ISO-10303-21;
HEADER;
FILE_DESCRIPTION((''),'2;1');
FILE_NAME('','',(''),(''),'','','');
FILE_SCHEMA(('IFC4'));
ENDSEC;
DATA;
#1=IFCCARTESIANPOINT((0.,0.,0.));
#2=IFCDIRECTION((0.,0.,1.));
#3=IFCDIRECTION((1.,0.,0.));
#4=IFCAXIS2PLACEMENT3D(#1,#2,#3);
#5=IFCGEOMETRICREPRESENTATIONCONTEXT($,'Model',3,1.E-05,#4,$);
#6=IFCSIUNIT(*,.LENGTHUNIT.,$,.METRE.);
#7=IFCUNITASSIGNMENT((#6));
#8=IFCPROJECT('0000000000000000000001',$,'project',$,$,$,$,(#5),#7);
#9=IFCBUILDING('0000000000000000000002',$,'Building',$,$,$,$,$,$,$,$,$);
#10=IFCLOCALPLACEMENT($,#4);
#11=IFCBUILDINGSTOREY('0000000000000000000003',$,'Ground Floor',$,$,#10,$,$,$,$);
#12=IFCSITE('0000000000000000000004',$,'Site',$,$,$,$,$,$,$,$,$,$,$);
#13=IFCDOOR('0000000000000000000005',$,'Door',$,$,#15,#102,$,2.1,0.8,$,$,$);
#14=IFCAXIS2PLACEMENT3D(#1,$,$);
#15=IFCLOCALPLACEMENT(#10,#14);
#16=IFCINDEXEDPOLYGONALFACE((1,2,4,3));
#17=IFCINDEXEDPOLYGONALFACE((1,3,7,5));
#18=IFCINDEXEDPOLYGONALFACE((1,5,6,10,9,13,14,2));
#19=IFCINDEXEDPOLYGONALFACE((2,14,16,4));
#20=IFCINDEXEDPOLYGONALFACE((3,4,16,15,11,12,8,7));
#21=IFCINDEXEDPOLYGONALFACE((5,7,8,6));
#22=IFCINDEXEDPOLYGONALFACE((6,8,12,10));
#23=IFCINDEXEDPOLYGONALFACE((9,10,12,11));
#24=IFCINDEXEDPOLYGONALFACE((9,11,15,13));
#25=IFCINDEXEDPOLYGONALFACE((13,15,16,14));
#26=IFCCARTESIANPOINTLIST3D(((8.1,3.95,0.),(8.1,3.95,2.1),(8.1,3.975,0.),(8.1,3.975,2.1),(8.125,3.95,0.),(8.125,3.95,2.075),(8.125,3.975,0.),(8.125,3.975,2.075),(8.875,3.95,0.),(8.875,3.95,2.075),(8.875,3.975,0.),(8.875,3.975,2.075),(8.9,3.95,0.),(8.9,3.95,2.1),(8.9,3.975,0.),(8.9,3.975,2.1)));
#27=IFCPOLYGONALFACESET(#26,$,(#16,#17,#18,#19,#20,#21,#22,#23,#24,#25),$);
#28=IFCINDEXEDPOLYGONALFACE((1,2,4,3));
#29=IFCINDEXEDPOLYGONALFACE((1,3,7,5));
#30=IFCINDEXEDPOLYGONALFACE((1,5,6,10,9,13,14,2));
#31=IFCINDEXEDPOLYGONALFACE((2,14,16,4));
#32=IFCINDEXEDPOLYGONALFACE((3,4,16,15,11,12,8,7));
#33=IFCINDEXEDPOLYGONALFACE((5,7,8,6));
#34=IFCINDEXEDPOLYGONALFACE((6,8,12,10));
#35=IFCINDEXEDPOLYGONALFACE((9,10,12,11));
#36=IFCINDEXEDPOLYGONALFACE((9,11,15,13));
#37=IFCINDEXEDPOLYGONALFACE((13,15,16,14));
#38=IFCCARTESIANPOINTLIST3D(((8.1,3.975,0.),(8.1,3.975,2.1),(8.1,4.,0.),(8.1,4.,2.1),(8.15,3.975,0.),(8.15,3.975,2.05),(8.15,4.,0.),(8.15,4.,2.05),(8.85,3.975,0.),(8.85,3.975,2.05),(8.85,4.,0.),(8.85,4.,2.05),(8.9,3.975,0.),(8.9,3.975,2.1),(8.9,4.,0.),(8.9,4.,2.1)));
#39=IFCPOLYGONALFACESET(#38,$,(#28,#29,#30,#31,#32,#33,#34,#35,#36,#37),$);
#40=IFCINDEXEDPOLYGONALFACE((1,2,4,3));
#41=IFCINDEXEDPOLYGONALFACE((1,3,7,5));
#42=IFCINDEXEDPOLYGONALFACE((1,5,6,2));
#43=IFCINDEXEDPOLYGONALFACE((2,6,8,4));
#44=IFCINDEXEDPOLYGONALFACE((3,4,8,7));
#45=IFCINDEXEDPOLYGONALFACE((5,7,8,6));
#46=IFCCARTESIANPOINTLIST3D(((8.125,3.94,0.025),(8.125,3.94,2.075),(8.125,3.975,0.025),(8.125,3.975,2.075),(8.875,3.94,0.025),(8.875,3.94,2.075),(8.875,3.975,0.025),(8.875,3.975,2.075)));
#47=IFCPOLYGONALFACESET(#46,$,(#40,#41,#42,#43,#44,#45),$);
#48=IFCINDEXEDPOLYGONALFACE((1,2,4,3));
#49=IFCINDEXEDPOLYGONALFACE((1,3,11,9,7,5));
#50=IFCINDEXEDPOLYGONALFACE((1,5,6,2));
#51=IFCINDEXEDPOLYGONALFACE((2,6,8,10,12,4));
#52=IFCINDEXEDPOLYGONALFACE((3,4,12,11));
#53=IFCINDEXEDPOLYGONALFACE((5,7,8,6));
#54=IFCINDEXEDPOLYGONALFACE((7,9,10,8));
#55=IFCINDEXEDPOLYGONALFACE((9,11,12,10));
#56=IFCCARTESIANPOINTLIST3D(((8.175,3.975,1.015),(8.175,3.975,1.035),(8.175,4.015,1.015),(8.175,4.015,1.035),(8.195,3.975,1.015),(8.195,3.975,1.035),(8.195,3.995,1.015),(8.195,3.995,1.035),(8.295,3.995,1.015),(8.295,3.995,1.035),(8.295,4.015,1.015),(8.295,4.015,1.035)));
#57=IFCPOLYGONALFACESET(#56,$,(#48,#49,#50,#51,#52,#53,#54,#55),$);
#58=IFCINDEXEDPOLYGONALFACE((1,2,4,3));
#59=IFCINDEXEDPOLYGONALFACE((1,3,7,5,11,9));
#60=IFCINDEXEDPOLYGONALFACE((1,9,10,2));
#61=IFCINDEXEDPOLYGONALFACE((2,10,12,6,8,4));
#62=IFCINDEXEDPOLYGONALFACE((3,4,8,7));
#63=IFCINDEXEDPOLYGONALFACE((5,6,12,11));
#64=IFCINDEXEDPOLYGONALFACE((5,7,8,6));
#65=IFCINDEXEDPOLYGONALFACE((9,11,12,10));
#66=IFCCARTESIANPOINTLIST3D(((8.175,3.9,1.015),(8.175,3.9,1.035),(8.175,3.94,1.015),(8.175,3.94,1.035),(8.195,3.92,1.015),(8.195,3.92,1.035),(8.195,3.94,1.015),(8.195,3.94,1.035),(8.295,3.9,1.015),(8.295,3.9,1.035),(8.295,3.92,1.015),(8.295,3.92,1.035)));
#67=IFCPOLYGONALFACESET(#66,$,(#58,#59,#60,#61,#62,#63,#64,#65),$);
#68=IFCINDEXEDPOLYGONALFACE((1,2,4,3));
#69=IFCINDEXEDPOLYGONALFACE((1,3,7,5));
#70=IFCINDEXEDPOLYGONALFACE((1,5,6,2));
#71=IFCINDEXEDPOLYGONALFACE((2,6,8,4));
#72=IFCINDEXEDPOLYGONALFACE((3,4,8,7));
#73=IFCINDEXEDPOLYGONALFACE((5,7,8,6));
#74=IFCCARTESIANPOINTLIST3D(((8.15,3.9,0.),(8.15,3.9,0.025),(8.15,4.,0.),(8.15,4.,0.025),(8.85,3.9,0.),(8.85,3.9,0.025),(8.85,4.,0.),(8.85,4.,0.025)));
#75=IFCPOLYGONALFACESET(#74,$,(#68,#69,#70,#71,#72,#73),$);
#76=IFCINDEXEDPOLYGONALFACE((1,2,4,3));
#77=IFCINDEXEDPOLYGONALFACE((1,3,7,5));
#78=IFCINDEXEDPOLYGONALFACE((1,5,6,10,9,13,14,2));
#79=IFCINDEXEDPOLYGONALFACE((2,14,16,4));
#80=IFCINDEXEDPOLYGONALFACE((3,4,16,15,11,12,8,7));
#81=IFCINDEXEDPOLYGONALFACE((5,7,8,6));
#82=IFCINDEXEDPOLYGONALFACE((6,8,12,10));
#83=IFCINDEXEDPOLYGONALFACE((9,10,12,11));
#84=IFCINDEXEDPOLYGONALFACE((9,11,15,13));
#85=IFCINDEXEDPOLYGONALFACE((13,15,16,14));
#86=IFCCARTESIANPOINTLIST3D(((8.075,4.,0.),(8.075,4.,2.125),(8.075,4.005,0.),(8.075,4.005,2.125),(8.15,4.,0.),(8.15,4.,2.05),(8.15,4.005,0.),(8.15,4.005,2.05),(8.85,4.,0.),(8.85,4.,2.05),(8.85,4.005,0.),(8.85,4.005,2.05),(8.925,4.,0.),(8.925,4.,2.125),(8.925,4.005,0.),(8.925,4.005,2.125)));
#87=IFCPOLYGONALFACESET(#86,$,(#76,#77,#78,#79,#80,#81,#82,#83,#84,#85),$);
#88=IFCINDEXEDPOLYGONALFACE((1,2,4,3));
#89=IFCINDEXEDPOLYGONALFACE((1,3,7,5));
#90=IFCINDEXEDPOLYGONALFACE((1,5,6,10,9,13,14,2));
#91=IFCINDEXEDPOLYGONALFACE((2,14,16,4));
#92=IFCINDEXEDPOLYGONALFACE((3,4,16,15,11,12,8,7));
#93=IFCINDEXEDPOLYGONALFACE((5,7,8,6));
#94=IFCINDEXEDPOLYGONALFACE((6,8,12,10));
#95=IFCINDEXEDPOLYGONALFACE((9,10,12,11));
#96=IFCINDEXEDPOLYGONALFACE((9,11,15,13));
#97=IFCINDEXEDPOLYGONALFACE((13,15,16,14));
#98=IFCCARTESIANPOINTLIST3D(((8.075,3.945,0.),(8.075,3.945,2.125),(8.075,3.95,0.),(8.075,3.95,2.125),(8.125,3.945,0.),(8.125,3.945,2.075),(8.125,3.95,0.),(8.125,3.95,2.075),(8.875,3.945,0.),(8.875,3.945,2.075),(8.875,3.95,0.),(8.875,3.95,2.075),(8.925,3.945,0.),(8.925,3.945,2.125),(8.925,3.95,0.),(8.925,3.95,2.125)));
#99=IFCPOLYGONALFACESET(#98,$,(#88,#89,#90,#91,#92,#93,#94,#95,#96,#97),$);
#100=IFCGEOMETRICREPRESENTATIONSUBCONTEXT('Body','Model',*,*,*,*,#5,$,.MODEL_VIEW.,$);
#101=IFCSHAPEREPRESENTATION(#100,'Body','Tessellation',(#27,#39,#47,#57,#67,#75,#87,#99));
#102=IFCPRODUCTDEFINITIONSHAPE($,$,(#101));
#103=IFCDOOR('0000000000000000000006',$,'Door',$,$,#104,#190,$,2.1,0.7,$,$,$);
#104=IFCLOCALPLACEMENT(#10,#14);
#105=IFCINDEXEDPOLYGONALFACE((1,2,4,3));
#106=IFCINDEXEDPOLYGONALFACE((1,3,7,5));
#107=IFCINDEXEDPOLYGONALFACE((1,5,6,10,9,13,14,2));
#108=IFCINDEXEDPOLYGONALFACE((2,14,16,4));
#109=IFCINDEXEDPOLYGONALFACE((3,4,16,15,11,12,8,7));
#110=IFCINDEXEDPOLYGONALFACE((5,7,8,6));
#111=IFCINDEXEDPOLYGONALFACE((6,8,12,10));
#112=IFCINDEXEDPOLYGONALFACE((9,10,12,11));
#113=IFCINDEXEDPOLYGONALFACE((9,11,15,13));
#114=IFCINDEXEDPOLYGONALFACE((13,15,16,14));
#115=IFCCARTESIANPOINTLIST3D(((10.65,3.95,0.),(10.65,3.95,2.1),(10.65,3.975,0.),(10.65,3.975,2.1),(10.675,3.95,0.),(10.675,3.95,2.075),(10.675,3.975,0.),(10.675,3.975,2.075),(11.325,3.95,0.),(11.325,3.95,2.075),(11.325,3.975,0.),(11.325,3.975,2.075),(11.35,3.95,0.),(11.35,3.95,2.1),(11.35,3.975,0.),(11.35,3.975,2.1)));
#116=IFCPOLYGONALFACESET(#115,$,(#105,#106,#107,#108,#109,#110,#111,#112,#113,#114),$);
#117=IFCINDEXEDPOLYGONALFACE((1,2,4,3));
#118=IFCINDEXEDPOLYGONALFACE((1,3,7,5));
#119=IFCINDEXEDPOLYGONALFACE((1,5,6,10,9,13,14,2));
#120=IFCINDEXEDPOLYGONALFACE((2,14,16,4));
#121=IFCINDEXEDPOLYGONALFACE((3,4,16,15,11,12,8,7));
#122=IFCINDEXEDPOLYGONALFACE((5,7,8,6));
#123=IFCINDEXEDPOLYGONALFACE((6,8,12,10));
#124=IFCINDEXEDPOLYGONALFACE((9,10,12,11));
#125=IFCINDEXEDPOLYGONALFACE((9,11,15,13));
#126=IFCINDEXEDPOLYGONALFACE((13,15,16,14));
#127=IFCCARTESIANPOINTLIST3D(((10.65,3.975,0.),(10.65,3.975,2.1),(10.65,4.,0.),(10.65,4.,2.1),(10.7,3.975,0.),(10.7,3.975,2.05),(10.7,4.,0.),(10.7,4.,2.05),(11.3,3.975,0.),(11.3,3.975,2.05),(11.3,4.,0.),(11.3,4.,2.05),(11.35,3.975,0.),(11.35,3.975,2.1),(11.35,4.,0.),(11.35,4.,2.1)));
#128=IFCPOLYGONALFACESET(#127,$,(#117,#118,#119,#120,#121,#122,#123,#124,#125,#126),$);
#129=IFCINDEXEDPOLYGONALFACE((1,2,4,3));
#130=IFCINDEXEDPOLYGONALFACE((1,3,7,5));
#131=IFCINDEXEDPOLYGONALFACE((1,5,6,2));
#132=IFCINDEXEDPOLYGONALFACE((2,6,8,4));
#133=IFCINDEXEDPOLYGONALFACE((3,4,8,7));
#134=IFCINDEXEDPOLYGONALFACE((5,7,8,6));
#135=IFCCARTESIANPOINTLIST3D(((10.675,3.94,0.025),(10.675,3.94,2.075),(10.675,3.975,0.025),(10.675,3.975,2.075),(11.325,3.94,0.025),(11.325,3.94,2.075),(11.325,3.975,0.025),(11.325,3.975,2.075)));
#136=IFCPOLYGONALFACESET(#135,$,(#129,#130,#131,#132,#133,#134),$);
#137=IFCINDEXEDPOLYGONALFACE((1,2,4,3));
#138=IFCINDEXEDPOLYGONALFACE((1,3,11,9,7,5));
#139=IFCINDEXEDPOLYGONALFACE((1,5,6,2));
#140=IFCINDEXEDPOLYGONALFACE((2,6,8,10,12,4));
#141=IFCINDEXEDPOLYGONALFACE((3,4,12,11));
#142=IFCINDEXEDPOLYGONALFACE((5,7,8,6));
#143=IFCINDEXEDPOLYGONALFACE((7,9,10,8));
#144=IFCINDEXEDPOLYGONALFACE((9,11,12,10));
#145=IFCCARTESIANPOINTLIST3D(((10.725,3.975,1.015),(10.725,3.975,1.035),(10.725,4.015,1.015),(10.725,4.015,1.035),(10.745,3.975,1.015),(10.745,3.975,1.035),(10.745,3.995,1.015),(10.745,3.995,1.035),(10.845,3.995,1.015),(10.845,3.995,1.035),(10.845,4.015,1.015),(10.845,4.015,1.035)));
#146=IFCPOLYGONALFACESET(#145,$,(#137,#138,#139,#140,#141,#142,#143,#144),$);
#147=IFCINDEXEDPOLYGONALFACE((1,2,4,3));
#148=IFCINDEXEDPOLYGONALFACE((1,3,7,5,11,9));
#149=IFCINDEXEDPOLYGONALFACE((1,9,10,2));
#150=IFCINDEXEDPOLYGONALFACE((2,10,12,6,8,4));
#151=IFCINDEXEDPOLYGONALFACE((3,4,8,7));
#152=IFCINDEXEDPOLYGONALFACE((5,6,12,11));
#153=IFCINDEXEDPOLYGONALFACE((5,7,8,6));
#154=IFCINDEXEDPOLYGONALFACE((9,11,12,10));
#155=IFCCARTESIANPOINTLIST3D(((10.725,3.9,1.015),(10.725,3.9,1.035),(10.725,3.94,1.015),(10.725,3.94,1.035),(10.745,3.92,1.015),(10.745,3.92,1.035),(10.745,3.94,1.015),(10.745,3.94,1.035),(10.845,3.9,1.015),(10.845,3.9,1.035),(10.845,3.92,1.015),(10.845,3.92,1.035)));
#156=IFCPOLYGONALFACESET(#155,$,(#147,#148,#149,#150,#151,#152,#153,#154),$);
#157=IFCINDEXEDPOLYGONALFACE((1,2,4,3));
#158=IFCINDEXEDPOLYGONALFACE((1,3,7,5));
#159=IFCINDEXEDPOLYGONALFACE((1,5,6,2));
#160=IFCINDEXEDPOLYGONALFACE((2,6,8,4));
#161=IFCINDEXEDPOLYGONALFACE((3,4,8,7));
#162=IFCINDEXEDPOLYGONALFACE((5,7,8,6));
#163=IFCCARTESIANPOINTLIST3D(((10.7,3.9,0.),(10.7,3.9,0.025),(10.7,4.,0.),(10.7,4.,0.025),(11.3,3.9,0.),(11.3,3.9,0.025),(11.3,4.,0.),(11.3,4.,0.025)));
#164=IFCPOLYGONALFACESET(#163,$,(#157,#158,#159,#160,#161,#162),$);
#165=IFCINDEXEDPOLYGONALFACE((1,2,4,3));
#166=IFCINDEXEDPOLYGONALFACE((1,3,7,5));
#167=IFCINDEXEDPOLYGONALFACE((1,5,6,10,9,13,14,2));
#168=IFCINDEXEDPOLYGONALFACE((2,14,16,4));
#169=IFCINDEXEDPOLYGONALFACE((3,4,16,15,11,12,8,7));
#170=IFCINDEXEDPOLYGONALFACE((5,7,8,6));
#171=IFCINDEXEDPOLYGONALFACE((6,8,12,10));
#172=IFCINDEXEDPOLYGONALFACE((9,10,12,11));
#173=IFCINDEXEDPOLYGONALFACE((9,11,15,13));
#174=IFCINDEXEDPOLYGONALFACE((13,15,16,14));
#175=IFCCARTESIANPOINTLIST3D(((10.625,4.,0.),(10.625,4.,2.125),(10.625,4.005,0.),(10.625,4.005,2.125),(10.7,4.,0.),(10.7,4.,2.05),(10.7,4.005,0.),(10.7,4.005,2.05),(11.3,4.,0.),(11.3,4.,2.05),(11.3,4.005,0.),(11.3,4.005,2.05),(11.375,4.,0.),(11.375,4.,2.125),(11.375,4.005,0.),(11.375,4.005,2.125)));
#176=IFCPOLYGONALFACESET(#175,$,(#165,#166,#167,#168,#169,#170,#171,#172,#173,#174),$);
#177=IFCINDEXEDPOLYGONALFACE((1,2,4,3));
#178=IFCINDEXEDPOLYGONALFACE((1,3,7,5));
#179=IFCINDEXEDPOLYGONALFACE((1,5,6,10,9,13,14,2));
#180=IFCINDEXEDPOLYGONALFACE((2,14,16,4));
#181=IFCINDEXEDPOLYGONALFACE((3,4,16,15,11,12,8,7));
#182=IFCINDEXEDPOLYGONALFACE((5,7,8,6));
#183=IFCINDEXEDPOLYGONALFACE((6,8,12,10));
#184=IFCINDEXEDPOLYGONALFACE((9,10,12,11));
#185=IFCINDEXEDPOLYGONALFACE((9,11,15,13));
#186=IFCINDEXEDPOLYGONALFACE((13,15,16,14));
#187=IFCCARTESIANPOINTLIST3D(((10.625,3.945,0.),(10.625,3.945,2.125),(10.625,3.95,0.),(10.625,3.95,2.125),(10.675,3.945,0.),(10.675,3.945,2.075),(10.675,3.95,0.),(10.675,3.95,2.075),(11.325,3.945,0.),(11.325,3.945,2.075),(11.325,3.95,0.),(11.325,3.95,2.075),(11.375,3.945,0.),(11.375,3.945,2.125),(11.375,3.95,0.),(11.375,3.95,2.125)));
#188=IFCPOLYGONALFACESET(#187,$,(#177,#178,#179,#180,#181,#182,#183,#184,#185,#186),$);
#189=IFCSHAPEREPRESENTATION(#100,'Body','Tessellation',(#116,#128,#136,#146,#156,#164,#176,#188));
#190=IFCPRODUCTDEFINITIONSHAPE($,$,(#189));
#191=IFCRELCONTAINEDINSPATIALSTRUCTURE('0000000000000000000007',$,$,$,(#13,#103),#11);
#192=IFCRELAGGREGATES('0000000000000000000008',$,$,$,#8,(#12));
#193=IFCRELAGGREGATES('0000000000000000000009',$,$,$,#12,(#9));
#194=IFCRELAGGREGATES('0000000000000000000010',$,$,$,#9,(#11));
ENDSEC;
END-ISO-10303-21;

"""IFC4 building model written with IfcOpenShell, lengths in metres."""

from ifc_helpers import new_model, si_unit, frame, origin_with_axes, place, context, subcontext, project, spatial, line, indexed_curve, outline, extrude, element, save


model = new_model("IFC4")

# Units and contexts
model_context = context("Model", 3, precision=1e-05, world=origin_with_axes())
body_context = subcontext(model_context, "Body", "Model", "MODEL_VIEW")
ifc_project = project(units=[si_unit("LENGTHUNIT", "METRE")], contexts=[model_context])

# Site, building, storey
site = spatial("IfcSite", under=ifc_project, Name="Site")
building = spatial("IfcBuilding", under=site, Name="Building")
storey_placement = place(None, origin_with_axes())
storey = spatial("IfcBuildingStorey", under=building, at=storey_placement, Name="Ground Floor")

# Doors
door_1_placement = place(storey_placement, frame((8.9, 4.0, 0.0), z_axis=(0.0, 0.0, 1.0), x_axis=(-1.0, 0.0, 0.0)))
element("IfcDoor", 1, at=door_1_placement, inside=storey, Name="Door", OverallHeight=2.1, OverallWidth=0.8, context=body_context, shape_type="SweptSolid", body=[
    extrude(outline(indexed_curve([(0.0, 0.0), (0.0, 2.1), (0.8, 2.1), (0.8, 0.0), (0.775, 0.0), (0.775, 2.075), (0.025, 2.075), (0.025, 0.0)], segments=[line(1, 2, 3, 4, 5, 6, 7, 8, 1)])), frame((0.0, 0.025, 0.0), z_axis=(0.0, -1.0, 0.0), x_axis=(1.0, 0.0, 0.0)), (0.0, 0.0, -1.0), 0.025),
    extrude(outline(indexed_curve([(0.0, 0.0), (0.0, 2.1), (0.8, 2.1), (0.8, 0.0), (0.75, 0.0), (0.75, 2.05), (0.05, 2.05), (0.05, 0.0)], segments=[line(1, 2, 3, 4, 5, 6, 7, 8, 1)])), frame((0.0, 0.0, 0.0), z_axis=(0.0, -1.0, 0.0), x_axis=(1.0, 0.0, 0.0)), (0.0, 0.0, -1.0), 0.025),
    extrude(outline(indexed_curve([(0.0, 0.0), (0.75, 0.0), (0.75, 0.035), (0.0, 0.035)], segments=[line(1, 2, 3, 4, 1)])), frame((0.025, 0.025, 0.025), z_axis=(0.0, 0.0, 1.0), x_axis=(1.0, 0.0, 0.0)), (0.0, 0.0, 1.0), 2.05),
    extrude(outline(indexed_curve([(0.0, 0.0), (0.0, -0.04), (-0.12, -0.04), (-0.12, -0.02), (-0.02, -0.02), (-0.02, 0.0)], segments=[line(1, 2, 3, 4, 5, 6, 1)])), frame((0.725, 0.025, 1.015), z_axis=(0.0, 0.0, 1.0), x_axis=(1.0, 0.0, 0.0)), (0.0, 0.0, 1.0), 0.02),
    extrude(outline(indexed_curve([(0.0, 0.0), (0.0, 0.04), (-0.12, 0.04), (-0.12, 0.02), (-0.02, 0.02), (-0.02, 0.0)], segments=[line(1, 2, 3, 4, 5, 6, 1)])), frame((0.725, 0.06, 1.015), z_axis=(0.0, 0.0, 1.0), x_axis=(1.0, 0.0, 0.0)), (0.0, 0.0, 1.0), 0.02),
    extrude(outline(indexed_curve([(0.0, 0.0), (0.7, 0.0), (0.7, 0.1), (0.0, 0.1)], segments=[line(1, 2, 3, 4, 1)])), frame((0.05, 0.0, 0.0), z_axis=(0.0, 0.0, 1.0), x_axis=(1.0, 0.0, 0.0)), (0.0, 0.0, 1.0), 0.025),
    extrude(outline(indexed_curve([(0.0, 0.0), (0.0, 2.125), (0.85, 2.125), (0.85, 0.0), (0.775, 0.0), (0.775, 2.05), (0.075, 2.05), (0.075, 0.0)], segments=[line(1, 2, 3, 4, 5, 6, 7, 8, 1)])), frame((-0.025, -0.005, 0.0), z_axis=(0.0, -1.0, 0.0), x_axis=(1.0, 0.0, 0.0)), (0.0, 0.0, -1.0), 0.005),
    extrude(outline(indexed_curve([(0.0, 0.0), (0.0, 2.125), (0.85, 2.125), (0.85, 0.0), (0.8, 0.0), (0.8, 2.075), (0.05, 2.075), (0.05, 0.0)], segments=[line(1, 2, 3, 4, 5, 6, 7, 8, 1)])), frame((-0.025, 0.05, 0.0), z_axis=(0.0, -1.0, 0.0), x_axis=(1.0, 0.0, 0.0)), (0.0, 0.0, -1.0), 0.005),
])
door_2_placement = place(storey_placement, frame((11.35, 4.0, 0.0), z_axis=(0.0, 0.0, 1.0), x_axis=(-1.0, 0.0, 0.0)))
element("IfcDoor", 2, at=door_2_placement, inside=storey, Name="Door", OverallHeight=2.1, OverallWidth=0.7, context=body_context, shape_type="SweptSolid", body=[
    extrude(outline(indexed_curve([(0.0, 0.0), (0.0, 2.1), (0.7, 2.1), (0.7, 0.0), (0.675, 0.0), (0.675, 2.075), (0.025, 2.075), (0.025, 0.0)], segments=[line(1, 2, 3, 4, 5, 6, 7, 8, 1)])), frame((0.0, 0.025, 0.0), z_axis=(0.0, -1.0, 0.0), x_axis=(1.0, 0.0, 0.0)), (0.0, 0.0, -1.0), 0.025),
    extrude(outline(indexed_curve([(0.0, 0.0), (0.0, 2.1), (0.7, 2.1), (0.7, 0.0), (0.65, 0.0), (0.65, 2.05), (0.05, 2.05), (0.05, 0.0)], segments=[line(1, 2, 3, 4, 5, 6, 7, 8, 1)])), frame((0.0, 0.0, 0.0), z_axis=(0.0, -1.0, 0.0), x_axis=(1.0, 0.0, 0.0)), (0.0, 0.0, -1.0), 0.025),
    extrude(outline(indexed_curve([(0.0, 0.0), (0.65, 0.0), (0.65, 0.035), (0.0, 0.035)], segments=[line(1, 2, 3, 4, 1)])), frame((0.025, 0.025, 0.025), z_axis=(0.0, 0.0, 1.0), x_axis=(1.0, 0.0, 0.0)), (0.0, 0.0, 1.0), 2.05),
    extrude(outline(indexed_curve([(0.0, 0.0), (0.0, -0.04), (-0.12, -0.04), (-0.12, -0.02), (-0.02, -0.02), (-0.02, 0.0)], segments=[line(1, 2, 3, 4, 5, 6, 1)])), frame((0.625, 0.025, 1.015), z_axis=(0.0, 0.0, 1.0), x_axis=(1.0, 0.0, 0.0)), (0.0, 0.0, 1.0), 0.02),
    extrude(outline(indexed_curve([(0.0, 0.0), (0.0, 0.04), (-0.12, 0.04), (-0.12, 0.02), (-0.02, 0.02), (-0.02, 0.0)], segments=[line(1, 2, 3, 4, 5, 6, 1)])), frame((0.625, 0.06, 1.015), z_axis=(0.0, 0.0, 1.0), x_axis=(1.0, 0.0, 0.0)), (0.0, 0.0, 1.0), 0.02),
    extrude(outline(indexed_curve([(0.0, 0.0), (0.6, 0.0), (0.6, 0.1), (0.0, 0.1)], segments=[line(1, 2, 3, 4, 1)])), frame((0.05, 0.0, 0.0), z_axis=(0.0, 0.0, 1.0), x_axis=(1.0, 0.0, 0.0)), (0.0, 0.0, 1.0), 0.025),
    extrude(outline(indexed_curve([(0.0, 0.0), (0.0, 2.125), (0.75, 2.125), (0.75, 0.0), (0.675, 0.0), (0.675, 2.05), (0.075, 2.05), (0.075, 0.0)], segments=[line(1, 2, 3, 4, 5, 6, 7, 8, 1)])), frame((-0.025, -0.005, 0.0), z_axis=(0.0, -1.0, 0.0), x_axis=(1.0, 0.0, 0.0)), (0.0, 0.0, -1.0), 0.005),
    extrude(outline(indexed_curve([(0.0, 0.0), (0.0, 2.125), (0.75, 2.125), (0.75, 0.0), (0.7, 0.0), (0.7, 2.075), (0.05, 2.075), (0.05, 0.0)], segments=[line(1, 2, 3, 4, 5, 6, 7, 8, 1)])), frame((-0.025, 0.05, 0.0), z_axis=(0.0, -1.0, 0.0), x_axis=(1.0, 0.0, 0.0)), (0.0, 0.0, -1.0), 0.005),
])

save(model, "model.ifc")
